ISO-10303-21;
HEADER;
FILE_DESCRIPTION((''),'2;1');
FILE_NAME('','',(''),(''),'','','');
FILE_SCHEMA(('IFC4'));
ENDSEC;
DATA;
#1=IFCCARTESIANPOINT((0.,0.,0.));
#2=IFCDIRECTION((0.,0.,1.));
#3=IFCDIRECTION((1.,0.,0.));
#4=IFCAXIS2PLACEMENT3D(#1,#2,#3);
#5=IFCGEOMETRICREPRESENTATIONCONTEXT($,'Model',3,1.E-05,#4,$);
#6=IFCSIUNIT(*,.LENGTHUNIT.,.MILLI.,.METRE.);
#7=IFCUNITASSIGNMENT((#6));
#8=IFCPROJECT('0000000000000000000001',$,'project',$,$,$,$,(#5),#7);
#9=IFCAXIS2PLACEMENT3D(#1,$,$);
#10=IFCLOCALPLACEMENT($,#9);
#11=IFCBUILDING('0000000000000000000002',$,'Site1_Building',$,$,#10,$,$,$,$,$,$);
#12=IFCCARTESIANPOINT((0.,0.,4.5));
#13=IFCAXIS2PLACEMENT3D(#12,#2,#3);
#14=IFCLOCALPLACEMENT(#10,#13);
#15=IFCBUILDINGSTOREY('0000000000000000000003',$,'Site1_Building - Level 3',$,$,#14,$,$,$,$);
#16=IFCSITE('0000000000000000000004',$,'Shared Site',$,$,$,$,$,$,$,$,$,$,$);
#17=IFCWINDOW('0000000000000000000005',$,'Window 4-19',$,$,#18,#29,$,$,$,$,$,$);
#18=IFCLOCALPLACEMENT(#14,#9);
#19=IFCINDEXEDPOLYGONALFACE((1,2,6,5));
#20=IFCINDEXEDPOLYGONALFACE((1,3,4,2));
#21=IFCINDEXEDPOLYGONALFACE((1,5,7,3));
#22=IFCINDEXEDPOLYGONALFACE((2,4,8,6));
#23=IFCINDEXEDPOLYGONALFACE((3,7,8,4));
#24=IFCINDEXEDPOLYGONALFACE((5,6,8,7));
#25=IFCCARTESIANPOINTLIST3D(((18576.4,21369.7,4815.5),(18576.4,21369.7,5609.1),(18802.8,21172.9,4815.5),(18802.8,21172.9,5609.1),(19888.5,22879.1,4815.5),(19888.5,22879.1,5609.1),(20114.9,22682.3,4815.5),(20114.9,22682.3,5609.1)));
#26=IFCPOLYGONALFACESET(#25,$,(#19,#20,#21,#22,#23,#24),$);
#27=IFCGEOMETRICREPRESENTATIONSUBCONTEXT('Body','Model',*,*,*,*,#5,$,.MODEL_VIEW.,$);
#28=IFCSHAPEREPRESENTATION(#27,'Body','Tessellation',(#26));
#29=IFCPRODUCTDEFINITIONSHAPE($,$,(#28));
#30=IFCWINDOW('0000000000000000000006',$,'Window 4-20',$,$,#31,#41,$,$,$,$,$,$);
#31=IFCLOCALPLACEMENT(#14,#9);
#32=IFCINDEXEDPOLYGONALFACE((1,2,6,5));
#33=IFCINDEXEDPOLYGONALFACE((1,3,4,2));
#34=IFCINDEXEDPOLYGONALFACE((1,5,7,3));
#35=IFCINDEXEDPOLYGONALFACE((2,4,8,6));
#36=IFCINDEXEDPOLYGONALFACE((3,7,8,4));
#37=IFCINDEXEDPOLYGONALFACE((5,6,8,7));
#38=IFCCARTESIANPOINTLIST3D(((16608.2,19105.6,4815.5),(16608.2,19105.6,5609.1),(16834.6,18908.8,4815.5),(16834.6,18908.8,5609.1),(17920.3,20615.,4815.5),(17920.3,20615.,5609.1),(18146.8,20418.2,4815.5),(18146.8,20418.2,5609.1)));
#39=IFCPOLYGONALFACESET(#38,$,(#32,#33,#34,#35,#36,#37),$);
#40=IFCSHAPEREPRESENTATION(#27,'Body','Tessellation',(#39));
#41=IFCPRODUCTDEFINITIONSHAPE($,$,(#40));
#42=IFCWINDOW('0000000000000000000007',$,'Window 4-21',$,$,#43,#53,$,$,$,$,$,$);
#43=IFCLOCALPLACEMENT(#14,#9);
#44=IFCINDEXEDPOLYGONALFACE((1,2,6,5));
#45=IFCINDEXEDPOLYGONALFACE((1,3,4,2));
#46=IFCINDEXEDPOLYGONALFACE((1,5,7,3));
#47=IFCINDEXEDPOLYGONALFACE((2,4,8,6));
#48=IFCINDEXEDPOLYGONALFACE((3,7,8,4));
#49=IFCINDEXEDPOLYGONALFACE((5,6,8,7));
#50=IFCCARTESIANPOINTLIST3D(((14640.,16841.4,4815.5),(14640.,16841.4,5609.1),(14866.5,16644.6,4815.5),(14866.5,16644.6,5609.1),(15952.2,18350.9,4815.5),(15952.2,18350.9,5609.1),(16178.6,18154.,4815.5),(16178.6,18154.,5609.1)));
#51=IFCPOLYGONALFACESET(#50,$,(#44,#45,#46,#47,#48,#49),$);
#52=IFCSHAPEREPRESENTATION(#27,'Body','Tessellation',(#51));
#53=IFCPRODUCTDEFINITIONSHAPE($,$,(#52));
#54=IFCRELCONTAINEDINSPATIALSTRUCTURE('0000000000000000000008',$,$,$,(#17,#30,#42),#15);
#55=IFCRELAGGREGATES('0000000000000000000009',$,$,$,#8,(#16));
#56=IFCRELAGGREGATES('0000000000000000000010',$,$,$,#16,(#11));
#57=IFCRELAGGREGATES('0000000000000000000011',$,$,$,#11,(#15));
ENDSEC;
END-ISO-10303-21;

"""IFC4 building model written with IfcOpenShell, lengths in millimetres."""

from ifc_helpers import new_model, si_unit, frame, origin, origin_with_axes, place, context, subcontext, project, spatial, indexed_curve, outline, extrude, element, save


model = new_model("IFC4")

# Units and contexts
model_context = context("Model", 3, precision=1e-05, world=origin_with_axes())
body_context = subcontext(model_context, "Body", "Model", "MODEL_VIEW")
ifc_project = project(units=[si_unit("LENGTHUNIT", "METRE", prefix="MILLI")], contexts=[model_context])

# Site, building, storey
site = spatial("IfcSite", under=ifc_project, Name="Shared Site")
building_placement = place(None, origin())
building = spatial("IfcBuilding", under=site, at=building_placement, Name="Site1_Building")
storey_placement = place(building_placement, frame((0.0, 0.0, 4.5), z_axis=(0.0, 0.0, 1.0), x_axis=(1.0, 0.0, 0.0)))
storey = spatial("IfcBuildingStorey", under=building, at=storey_placement, Name="Site1_Building - Level 3")

# Windows
for number, where, z_axis, x_axis, name in (
    (1, (19888.5, 22879.1, 4815.5), (0.0, 0.0, 1.0), (-0.656059, -0.75471, 0.0), "Window 4-19"),
    (2, (17920.3, 20615.0, 4815.5), (0.0, 0.0, 1.0), (-0.656059, -0.75471, 0.0), "Window 4-20"),
    (3, (15952.2, 18350.9, 4815.5), (0.0, 0.0, 1.0), (-0.656059, -0.75471, 0.0), "Window 4-21"),
):
    element("IfcWindow", number, at=place(storey_placement, frame(where, z_axis=z_axis, x_axis=x_axis)), inside=storey, Name=name, context=body_context, shape_type="SweptSolid", body=[
        extrude(outline(indexed_curve([(0.0, 0.0), (0.0, 300.0), (2000.0, 300.0), (2000.0, 0.0), (0.0, 0.0)], self_intersect=False)), origin_with_axes(), (0.0, 0.0, 1.0), 793.6),
    ])

save(model, "model.ifc")
